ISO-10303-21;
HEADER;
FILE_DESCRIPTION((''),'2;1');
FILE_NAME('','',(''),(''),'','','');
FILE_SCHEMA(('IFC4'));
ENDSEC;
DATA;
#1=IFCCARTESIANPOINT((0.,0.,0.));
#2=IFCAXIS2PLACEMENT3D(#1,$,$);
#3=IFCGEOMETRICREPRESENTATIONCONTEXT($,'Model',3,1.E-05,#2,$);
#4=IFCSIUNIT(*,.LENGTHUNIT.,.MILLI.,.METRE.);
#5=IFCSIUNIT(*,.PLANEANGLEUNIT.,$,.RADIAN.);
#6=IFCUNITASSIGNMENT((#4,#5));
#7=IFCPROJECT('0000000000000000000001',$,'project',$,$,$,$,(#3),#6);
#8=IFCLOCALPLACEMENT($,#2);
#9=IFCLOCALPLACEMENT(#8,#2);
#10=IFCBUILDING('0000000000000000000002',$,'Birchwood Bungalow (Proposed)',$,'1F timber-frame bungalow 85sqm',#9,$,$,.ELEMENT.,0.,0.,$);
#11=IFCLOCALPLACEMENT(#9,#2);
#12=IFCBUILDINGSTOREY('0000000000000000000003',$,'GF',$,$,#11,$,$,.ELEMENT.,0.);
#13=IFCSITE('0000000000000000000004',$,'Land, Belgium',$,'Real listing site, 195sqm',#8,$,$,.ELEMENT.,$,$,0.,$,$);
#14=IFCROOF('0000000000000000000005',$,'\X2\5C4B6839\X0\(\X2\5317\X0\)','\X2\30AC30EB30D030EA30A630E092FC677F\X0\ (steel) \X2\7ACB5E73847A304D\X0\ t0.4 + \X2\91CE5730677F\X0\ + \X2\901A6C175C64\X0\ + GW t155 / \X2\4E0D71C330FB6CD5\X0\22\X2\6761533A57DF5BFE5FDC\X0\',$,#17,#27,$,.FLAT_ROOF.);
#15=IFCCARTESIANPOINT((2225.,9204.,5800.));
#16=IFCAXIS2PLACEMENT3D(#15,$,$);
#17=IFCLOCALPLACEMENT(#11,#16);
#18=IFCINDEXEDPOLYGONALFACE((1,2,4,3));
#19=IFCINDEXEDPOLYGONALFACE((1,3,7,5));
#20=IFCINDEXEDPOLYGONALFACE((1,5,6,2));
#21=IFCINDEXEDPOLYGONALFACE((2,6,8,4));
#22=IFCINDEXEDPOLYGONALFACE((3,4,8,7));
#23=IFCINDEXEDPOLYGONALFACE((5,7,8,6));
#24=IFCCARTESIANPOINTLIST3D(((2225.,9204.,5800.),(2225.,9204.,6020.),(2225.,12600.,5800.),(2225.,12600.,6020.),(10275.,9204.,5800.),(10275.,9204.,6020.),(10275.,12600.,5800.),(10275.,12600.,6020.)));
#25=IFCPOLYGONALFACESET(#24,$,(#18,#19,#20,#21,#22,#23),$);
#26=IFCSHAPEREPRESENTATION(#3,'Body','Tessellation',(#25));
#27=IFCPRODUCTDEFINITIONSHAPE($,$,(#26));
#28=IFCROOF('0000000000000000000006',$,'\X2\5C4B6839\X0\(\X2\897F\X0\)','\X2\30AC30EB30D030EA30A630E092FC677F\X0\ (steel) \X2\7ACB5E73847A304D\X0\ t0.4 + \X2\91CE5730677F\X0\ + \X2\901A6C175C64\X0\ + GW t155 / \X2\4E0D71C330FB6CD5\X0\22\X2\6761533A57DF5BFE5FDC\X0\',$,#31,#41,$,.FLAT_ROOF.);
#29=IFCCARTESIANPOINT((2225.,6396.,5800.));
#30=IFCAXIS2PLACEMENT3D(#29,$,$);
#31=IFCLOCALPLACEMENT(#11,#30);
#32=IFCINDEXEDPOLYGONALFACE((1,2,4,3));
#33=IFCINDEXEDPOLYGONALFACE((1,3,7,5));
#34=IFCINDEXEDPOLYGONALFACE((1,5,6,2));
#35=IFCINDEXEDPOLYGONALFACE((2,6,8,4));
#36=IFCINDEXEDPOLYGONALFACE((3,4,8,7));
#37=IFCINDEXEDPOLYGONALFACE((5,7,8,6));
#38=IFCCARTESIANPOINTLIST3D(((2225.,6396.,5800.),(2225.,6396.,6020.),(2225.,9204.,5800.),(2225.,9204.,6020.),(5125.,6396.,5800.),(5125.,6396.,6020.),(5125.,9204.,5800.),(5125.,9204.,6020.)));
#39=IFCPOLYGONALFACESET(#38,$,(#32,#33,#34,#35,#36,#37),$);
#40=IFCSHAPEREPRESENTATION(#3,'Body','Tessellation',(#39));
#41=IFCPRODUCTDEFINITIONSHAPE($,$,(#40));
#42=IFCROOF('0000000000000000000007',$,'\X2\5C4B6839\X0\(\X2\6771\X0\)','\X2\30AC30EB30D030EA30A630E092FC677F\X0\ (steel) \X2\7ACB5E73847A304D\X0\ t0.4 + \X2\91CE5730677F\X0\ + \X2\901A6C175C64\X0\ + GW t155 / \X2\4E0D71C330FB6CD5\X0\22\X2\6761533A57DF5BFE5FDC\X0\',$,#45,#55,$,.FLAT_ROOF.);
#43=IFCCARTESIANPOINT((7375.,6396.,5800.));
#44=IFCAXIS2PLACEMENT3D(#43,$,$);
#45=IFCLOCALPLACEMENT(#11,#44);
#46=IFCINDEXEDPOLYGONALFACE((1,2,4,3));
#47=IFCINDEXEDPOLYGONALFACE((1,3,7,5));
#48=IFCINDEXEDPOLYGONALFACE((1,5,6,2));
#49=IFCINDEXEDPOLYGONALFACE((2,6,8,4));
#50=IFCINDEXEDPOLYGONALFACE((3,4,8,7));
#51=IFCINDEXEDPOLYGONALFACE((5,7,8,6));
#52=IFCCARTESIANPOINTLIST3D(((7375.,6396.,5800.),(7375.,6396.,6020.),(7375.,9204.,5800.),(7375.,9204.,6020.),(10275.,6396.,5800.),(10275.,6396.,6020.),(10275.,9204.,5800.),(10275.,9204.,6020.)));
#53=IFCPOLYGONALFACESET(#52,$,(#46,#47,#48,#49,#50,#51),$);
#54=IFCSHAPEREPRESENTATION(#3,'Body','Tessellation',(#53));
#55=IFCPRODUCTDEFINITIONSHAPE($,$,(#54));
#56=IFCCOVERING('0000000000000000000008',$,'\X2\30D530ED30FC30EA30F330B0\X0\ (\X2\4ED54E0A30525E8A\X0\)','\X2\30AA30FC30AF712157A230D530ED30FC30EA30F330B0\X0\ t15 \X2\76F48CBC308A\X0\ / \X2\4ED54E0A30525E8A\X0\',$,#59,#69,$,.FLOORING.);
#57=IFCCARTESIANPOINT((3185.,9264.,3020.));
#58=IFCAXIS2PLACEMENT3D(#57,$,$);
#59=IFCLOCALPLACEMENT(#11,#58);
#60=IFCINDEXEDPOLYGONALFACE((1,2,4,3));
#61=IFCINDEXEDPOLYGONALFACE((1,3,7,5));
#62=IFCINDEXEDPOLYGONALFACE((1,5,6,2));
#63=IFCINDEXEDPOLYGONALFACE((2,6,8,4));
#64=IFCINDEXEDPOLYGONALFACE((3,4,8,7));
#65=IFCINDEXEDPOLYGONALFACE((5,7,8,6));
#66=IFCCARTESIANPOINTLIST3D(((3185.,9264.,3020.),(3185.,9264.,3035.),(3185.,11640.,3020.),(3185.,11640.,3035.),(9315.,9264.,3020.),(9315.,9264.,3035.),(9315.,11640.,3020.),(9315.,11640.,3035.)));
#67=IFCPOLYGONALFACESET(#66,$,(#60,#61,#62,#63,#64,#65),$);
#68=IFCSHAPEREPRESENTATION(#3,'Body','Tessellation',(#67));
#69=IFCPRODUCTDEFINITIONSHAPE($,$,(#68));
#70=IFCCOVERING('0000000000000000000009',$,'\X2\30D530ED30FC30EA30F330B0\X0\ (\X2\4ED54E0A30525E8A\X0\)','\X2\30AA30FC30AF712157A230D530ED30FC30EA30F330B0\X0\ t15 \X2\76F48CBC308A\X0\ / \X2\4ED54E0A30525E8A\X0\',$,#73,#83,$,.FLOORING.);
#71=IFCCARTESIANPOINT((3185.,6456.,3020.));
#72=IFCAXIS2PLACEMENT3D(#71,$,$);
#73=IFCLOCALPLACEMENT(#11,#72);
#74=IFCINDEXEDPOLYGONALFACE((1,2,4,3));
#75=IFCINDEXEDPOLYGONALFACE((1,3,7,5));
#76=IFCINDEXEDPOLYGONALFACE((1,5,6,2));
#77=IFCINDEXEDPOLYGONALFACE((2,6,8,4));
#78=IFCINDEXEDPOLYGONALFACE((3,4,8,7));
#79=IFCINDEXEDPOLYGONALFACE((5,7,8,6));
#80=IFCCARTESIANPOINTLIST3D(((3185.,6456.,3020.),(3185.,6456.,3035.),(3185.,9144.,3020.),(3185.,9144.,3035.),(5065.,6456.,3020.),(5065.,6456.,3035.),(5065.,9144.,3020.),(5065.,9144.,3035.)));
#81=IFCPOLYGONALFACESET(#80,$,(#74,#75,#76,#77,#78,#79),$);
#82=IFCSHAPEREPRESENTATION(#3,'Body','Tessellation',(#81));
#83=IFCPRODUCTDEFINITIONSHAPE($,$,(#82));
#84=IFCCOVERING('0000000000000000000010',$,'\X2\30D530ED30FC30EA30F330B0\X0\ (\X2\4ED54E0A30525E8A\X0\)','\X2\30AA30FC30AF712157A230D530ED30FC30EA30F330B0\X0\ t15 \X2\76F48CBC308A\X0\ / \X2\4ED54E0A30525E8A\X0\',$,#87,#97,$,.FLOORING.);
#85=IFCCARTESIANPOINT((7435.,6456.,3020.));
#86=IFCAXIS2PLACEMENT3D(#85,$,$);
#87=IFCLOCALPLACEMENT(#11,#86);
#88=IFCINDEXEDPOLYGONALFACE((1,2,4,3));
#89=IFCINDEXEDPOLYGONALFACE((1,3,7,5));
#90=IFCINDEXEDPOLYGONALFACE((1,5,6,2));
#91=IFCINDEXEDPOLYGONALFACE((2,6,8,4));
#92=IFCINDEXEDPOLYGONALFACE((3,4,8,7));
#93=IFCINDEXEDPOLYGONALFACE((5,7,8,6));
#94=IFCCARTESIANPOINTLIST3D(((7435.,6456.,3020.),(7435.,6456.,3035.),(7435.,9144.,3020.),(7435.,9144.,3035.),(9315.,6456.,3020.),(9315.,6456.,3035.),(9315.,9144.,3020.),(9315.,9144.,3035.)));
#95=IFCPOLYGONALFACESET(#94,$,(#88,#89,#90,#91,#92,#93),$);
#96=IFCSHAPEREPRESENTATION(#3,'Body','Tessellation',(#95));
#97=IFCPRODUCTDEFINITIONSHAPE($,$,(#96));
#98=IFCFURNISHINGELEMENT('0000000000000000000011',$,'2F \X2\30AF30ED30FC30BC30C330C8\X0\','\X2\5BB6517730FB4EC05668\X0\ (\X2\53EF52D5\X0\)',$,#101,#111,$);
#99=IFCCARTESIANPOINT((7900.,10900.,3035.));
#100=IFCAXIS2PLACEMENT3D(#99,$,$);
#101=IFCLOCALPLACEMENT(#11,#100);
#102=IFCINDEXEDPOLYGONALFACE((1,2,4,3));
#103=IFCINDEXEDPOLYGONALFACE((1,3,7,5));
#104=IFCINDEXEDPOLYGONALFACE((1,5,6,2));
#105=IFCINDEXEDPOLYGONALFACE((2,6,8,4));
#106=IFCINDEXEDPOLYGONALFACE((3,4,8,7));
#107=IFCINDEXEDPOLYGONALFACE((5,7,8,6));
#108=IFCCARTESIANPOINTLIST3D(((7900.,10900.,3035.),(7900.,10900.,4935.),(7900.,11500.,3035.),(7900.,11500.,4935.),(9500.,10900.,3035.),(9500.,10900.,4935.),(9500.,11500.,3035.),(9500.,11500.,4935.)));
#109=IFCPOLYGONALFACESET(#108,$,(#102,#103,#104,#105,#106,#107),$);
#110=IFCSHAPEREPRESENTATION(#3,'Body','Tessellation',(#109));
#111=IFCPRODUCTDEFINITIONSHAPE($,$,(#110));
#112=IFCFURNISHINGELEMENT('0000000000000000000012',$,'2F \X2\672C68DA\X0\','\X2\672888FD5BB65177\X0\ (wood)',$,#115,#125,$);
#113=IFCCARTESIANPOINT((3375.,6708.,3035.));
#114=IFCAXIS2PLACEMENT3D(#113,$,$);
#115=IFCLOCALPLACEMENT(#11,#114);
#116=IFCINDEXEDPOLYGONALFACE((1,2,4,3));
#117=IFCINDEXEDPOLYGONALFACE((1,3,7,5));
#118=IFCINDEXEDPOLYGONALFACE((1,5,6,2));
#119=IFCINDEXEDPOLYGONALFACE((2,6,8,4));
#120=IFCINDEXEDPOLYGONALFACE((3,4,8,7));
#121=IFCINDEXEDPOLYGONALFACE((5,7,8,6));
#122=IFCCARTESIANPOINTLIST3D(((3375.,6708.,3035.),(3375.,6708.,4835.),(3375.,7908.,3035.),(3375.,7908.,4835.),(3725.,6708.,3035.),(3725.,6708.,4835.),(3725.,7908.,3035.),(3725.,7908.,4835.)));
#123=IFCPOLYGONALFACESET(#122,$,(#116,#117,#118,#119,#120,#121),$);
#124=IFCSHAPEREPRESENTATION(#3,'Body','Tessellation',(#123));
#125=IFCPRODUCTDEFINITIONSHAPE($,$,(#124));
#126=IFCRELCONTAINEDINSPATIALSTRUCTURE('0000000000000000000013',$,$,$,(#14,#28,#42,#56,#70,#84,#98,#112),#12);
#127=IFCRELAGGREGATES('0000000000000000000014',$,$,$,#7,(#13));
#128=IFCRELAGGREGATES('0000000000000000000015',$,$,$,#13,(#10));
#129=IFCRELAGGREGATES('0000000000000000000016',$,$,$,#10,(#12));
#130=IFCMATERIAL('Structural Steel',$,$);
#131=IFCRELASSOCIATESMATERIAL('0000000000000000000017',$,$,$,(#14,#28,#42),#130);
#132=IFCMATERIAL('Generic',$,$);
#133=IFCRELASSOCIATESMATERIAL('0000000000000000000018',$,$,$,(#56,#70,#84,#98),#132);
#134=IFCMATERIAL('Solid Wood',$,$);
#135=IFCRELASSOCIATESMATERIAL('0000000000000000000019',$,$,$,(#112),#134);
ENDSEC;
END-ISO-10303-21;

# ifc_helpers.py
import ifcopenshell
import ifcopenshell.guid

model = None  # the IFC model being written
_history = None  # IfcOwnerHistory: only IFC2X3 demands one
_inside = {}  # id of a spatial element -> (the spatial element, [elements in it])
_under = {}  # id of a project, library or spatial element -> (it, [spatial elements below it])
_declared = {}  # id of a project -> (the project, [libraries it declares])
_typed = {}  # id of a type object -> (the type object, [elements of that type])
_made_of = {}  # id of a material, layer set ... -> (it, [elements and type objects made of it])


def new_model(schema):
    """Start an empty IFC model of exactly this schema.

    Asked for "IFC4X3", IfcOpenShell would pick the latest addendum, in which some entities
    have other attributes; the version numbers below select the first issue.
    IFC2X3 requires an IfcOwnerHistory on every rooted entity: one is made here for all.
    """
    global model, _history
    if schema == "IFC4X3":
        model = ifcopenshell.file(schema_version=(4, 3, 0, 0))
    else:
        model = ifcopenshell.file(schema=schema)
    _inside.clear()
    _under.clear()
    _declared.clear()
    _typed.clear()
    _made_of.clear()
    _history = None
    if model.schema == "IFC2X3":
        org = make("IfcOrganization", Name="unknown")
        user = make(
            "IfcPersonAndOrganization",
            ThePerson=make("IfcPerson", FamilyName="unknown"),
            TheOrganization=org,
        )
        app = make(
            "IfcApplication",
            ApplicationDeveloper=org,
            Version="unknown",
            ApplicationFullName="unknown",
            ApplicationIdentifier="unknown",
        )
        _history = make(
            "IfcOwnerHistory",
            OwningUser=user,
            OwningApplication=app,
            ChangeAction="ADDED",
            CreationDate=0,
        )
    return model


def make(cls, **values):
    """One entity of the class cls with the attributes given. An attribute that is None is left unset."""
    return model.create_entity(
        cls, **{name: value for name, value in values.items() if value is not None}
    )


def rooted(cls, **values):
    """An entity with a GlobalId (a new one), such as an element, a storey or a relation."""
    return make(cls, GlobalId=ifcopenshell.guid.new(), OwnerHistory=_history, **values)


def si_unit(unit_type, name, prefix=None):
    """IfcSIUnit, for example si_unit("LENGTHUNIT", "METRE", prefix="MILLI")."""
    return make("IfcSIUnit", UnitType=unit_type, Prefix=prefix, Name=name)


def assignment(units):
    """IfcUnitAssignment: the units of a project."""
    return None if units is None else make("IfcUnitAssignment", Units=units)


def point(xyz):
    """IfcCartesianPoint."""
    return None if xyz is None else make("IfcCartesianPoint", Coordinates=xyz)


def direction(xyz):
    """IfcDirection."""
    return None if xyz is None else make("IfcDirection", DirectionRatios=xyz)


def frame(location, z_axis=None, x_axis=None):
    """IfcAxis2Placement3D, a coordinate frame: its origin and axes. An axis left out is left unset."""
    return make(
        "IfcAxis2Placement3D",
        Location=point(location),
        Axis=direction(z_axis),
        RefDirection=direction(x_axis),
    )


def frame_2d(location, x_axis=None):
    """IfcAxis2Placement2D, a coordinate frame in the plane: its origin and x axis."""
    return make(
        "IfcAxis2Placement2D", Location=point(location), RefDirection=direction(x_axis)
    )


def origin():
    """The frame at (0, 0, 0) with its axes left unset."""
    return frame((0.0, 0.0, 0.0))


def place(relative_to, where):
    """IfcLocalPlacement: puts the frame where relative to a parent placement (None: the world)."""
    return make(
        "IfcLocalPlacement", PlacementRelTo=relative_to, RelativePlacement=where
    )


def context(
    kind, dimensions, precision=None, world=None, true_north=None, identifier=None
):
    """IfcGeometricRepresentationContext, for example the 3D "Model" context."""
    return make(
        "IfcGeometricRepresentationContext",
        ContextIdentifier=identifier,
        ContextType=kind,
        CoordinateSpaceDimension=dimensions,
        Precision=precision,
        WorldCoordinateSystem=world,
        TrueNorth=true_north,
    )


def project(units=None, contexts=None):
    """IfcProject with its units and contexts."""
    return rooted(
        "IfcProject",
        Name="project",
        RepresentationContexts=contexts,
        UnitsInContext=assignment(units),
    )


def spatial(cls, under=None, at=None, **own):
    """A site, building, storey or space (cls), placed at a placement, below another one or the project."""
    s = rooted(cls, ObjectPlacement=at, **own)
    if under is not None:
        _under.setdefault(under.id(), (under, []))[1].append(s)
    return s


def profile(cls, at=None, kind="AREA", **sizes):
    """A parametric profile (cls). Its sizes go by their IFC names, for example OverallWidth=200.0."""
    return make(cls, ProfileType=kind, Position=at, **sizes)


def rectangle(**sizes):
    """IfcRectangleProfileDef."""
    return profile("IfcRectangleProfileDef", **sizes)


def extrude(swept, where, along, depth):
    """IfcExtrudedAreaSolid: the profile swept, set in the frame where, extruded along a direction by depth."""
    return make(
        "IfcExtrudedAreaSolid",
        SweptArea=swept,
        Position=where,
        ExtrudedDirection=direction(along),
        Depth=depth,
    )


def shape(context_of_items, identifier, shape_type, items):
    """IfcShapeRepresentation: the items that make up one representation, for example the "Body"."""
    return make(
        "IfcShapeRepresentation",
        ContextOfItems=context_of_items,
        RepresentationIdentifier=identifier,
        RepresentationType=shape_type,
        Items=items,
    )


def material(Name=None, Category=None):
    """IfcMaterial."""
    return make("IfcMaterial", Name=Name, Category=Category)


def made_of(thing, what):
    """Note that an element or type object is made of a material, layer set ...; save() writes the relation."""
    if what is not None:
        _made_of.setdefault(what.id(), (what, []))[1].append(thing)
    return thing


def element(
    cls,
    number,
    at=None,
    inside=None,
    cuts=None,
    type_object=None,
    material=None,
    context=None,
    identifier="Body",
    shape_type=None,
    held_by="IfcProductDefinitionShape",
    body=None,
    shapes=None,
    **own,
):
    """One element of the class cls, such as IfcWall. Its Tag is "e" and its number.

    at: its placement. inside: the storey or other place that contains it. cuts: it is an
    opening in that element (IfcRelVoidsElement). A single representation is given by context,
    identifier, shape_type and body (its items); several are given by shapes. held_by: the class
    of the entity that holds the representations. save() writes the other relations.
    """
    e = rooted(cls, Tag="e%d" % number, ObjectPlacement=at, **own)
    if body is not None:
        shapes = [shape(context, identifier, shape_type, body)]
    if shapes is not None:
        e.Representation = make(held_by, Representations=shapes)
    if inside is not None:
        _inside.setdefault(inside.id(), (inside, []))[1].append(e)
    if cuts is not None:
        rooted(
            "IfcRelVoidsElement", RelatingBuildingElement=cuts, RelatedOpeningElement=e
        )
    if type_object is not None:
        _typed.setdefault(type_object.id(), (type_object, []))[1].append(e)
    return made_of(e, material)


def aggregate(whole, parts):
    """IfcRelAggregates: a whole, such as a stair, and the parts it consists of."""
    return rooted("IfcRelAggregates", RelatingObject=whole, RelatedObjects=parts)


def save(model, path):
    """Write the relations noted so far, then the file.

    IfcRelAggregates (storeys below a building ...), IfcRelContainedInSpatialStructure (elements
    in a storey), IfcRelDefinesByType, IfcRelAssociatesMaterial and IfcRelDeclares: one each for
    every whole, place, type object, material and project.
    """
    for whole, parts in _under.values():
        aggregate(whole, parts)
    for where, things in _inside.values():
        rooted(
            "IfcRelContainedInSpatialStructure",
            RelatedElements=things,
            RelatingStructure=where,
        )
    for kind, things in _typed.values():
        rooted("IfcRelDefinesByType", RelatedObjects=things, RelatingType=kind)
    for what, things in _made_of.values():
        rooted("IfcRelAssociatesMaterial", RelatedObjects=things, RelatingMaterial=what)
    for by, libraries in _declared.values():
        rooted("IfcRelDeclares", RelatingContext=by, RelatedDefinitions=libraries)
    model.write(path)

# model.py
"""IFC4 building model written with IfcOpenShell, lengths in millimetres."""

from ifc_helpers import new_model, si_unit, frame, frame_2d, origin, place, context, project, spatial, rectangle, extrude, material, element, save


model = new_model("IFC4")

# Units and contexts
model_context = context("Model", 3, precision=1e-05, world=origin())
ifc_project = project(units=[si_unit("LENGTHUNIT", "METRE", prefix="MILLI"), si_unit("PLANEANGLEUNIT", "RADIAN")], contexts=[model_context])

# Site, building, storey
site_placement = place(None, origin())
site = spatial("IfcSite", under=ifc_project, at=site_placement, Name="Land, Belgium", ObjectType="Real listing site, 195sqm", CompositionType="ELEMENT", RefElevation=0.0)
building_placement = place(site_placement, origin())
building = spatial("IfcBuilding", under=site, at=building_placement, Name="Birchwood Bungalow (Proposed)", ObjectType="1F timber-frame bungalow 85sqm", CompositionType="ELEMENT", ElevationOfRefHeight=0.0, ElevationOfTerrain=0.0)
storey_placement = place(building_placement, origin())
storey = spatial("IfcBuildingStorey", under=building, at=storey_placement, Name="GF", CompositionType="ELEMENT", Elevation=0.0)

# Shared definitions
ifc_material_1 = material(Name="Solid Wood")

# Roofs
ifc_material_2 = material(Name="Structural Steel")
for number, where, name in (
    (1, (2225.0, 9204.0, 5800.0), "屋根(北)"),
):
    element("IfcRoof", number, at=place(storey_placement, frame(where)), inside=storey, material=ifc_material_2, Name=name, Description="ガルバリウム鋼板 (steel) 立平葺き t0.4 + 野地板 + 通気層 + GW t155 / 不燃・法22条区域対応", PredefinedType="FLAT_ROOF", context=model_context, shape_type="SweptSolid", body=[
        extrude(rectangle(XDim=8050.0, YDim=3396.0, at=frame_2d((4025.0, 1698.0))), frame((2225.0, 9204.0, 5800.0)), (0.0, 0.0, 1.0), 220.0),
    ])
roof_1_placement = place(storey_placement, frame((2225.0, 6396.0, 5800.0)))
element("IfcRoof", 2, at=roof_1_placement, inside=storey, material=ifc_material_2, Name="屋根(西)", Description="ガルバリウム鋼板 (steel) 立平葺き t0.4 + 野地板 + 通気層 + GW t155 / 不燃・法22条区域対応", PredefinedType="FLAT_ROOF", context=model_context, shape_type="SweptSolid", body=[
    extrude(rectangle(XDim=2900.0, YDim=2808.0, at=frame_2d((1450.0, 1404.0))), frame((2225.0, 6396.0, 5800.0)), (0.0, 0.0, 1.0), 220.0),
])
roof_2_placement = place(storey_placement, frame((7375.0, 6396.0, 5800.0)))
element("IfcRoof", 3, at=roof_2_placement, inside=storey, material=ifc_material_2, Name="屋根(東)", Description="ガルバリウム鋼板 (steel) 立平葺き t0.4 + 野地板 + 通気層 + GW t155 / 不燃・法22条区域対応", PredefinedType="FLAT_ROOF", context=model_context, shape_type="SweptSolid", body=[
    extrude(rectangle(XDim=2900.0, YDim=2808.0, at=frame_2d((1450.0, 1404.0))), frame((7375.0, 6396.0, 5800.0)), (0.0, 0.0, 1.0), 220.0),
])

# Coverings
ifc_material_3 = material(Name="Generic")
covering_1_placement = place(storey_placement, frame((3185.0, 9264.0, 3020.0)))
element("IfcCovering", 4, at=covering_1_placement, inside=storey, material=ifc_material_3, Name="フローリング (仕上げ床)", Description="オーク無垢フローリング t15 直貼り / 仕上げ床", PredefinedType="FLOORING", context=model_context, shape_type="SweptSolid", body=[
    extrude(rectangle(XDim=6130.0, YDim=2376.0, at=frame_2d((3065.0, 1188.0))), frame((3185.0, 9264.0, 3020.0)), (0.0, 0.0, 1.0), 15.0),
])
covering_2_placement = place(storey_placement, frame((3185.0, 6456.0, 3020.0)))
element("IfcCovering", 5, at=covering_2_placement, inside=storey, material=ifc_material_3, Name="フローリング (仕上げ床)", Description="オーク無垢フローリング t15 直貼り / 仕上げ床", PredefinedType="FLOORING", context=model_context, shape_type="SweptSolid", body=[
    extrude(rectangle(XDim=1880.0, YDim=2688.0, at=frame_2d((940.0, 1344.0))), frame((3185.0, 6456.0, 3020.0)), (0.0, 0.0, 1.0), 15.0),
])
covering_3_placement = place(storey_placement, frame((7435.0, 6456.0, 3020.0)))
element("IfcCovering", 6, at=covering_3_placement, inside=storey, material=ifc_material_3, Name="フローリング (仕上げ床)", Description="オーク無垢フローリング t15 直貼り / 仕上げ床", PredefinedType="FLOORING", context=model_context, shape_type="SweptSolid", body=[
    extrude(rectangle(XDim=1880.0, YDim=2688.0, at=frame_2d((940.0, 1344.0))), frame((7435.0, 6456.0, 3020.0)), (0.0, 0.0, 1.0), 15.0),
])

# Furnishing elements
furnishing_1_placement = place(storey_placement, frame((7900.0, 10900.0, 3035.0)))
element("IfcFurnishingElement", 7, at=furnishing_1_placement, inside=storey, material=ifc_material_3, Name="2F クローゼット", Description="家具・什器 (可動)", context=model_context, shape_type="SweptSolid", body=[
    extrude(rectangle(XDim=1600.0, YDim=600.0, at=frame_2d((800.0, 300.0))), frame((7900.0, 10900.0, 3035.0)), (0.0, 0.0, 1.0), 1900.0),
])
furnishing_2_placement = place(storey_placement, frame((3375.0, 6708.0, 3035.0)))
element("IfcFurnishingElement", 8, at=furnishing_2_placement, inside=storey, material=ifc_material_1, Name="2F 本棚", Description="木製家具 (wood)", context=model_context, shape_type="SweptSolid", body=[
    extrude(rectangle(XDim=350.0, YDim=1200.0, at=frame_2d((175.0, 600.0))), frame((3375.0, 6708.0, 3035.0)), (0.0, 0.0, 1.0), 1800.0),
])

save(model, "model.ifc")
